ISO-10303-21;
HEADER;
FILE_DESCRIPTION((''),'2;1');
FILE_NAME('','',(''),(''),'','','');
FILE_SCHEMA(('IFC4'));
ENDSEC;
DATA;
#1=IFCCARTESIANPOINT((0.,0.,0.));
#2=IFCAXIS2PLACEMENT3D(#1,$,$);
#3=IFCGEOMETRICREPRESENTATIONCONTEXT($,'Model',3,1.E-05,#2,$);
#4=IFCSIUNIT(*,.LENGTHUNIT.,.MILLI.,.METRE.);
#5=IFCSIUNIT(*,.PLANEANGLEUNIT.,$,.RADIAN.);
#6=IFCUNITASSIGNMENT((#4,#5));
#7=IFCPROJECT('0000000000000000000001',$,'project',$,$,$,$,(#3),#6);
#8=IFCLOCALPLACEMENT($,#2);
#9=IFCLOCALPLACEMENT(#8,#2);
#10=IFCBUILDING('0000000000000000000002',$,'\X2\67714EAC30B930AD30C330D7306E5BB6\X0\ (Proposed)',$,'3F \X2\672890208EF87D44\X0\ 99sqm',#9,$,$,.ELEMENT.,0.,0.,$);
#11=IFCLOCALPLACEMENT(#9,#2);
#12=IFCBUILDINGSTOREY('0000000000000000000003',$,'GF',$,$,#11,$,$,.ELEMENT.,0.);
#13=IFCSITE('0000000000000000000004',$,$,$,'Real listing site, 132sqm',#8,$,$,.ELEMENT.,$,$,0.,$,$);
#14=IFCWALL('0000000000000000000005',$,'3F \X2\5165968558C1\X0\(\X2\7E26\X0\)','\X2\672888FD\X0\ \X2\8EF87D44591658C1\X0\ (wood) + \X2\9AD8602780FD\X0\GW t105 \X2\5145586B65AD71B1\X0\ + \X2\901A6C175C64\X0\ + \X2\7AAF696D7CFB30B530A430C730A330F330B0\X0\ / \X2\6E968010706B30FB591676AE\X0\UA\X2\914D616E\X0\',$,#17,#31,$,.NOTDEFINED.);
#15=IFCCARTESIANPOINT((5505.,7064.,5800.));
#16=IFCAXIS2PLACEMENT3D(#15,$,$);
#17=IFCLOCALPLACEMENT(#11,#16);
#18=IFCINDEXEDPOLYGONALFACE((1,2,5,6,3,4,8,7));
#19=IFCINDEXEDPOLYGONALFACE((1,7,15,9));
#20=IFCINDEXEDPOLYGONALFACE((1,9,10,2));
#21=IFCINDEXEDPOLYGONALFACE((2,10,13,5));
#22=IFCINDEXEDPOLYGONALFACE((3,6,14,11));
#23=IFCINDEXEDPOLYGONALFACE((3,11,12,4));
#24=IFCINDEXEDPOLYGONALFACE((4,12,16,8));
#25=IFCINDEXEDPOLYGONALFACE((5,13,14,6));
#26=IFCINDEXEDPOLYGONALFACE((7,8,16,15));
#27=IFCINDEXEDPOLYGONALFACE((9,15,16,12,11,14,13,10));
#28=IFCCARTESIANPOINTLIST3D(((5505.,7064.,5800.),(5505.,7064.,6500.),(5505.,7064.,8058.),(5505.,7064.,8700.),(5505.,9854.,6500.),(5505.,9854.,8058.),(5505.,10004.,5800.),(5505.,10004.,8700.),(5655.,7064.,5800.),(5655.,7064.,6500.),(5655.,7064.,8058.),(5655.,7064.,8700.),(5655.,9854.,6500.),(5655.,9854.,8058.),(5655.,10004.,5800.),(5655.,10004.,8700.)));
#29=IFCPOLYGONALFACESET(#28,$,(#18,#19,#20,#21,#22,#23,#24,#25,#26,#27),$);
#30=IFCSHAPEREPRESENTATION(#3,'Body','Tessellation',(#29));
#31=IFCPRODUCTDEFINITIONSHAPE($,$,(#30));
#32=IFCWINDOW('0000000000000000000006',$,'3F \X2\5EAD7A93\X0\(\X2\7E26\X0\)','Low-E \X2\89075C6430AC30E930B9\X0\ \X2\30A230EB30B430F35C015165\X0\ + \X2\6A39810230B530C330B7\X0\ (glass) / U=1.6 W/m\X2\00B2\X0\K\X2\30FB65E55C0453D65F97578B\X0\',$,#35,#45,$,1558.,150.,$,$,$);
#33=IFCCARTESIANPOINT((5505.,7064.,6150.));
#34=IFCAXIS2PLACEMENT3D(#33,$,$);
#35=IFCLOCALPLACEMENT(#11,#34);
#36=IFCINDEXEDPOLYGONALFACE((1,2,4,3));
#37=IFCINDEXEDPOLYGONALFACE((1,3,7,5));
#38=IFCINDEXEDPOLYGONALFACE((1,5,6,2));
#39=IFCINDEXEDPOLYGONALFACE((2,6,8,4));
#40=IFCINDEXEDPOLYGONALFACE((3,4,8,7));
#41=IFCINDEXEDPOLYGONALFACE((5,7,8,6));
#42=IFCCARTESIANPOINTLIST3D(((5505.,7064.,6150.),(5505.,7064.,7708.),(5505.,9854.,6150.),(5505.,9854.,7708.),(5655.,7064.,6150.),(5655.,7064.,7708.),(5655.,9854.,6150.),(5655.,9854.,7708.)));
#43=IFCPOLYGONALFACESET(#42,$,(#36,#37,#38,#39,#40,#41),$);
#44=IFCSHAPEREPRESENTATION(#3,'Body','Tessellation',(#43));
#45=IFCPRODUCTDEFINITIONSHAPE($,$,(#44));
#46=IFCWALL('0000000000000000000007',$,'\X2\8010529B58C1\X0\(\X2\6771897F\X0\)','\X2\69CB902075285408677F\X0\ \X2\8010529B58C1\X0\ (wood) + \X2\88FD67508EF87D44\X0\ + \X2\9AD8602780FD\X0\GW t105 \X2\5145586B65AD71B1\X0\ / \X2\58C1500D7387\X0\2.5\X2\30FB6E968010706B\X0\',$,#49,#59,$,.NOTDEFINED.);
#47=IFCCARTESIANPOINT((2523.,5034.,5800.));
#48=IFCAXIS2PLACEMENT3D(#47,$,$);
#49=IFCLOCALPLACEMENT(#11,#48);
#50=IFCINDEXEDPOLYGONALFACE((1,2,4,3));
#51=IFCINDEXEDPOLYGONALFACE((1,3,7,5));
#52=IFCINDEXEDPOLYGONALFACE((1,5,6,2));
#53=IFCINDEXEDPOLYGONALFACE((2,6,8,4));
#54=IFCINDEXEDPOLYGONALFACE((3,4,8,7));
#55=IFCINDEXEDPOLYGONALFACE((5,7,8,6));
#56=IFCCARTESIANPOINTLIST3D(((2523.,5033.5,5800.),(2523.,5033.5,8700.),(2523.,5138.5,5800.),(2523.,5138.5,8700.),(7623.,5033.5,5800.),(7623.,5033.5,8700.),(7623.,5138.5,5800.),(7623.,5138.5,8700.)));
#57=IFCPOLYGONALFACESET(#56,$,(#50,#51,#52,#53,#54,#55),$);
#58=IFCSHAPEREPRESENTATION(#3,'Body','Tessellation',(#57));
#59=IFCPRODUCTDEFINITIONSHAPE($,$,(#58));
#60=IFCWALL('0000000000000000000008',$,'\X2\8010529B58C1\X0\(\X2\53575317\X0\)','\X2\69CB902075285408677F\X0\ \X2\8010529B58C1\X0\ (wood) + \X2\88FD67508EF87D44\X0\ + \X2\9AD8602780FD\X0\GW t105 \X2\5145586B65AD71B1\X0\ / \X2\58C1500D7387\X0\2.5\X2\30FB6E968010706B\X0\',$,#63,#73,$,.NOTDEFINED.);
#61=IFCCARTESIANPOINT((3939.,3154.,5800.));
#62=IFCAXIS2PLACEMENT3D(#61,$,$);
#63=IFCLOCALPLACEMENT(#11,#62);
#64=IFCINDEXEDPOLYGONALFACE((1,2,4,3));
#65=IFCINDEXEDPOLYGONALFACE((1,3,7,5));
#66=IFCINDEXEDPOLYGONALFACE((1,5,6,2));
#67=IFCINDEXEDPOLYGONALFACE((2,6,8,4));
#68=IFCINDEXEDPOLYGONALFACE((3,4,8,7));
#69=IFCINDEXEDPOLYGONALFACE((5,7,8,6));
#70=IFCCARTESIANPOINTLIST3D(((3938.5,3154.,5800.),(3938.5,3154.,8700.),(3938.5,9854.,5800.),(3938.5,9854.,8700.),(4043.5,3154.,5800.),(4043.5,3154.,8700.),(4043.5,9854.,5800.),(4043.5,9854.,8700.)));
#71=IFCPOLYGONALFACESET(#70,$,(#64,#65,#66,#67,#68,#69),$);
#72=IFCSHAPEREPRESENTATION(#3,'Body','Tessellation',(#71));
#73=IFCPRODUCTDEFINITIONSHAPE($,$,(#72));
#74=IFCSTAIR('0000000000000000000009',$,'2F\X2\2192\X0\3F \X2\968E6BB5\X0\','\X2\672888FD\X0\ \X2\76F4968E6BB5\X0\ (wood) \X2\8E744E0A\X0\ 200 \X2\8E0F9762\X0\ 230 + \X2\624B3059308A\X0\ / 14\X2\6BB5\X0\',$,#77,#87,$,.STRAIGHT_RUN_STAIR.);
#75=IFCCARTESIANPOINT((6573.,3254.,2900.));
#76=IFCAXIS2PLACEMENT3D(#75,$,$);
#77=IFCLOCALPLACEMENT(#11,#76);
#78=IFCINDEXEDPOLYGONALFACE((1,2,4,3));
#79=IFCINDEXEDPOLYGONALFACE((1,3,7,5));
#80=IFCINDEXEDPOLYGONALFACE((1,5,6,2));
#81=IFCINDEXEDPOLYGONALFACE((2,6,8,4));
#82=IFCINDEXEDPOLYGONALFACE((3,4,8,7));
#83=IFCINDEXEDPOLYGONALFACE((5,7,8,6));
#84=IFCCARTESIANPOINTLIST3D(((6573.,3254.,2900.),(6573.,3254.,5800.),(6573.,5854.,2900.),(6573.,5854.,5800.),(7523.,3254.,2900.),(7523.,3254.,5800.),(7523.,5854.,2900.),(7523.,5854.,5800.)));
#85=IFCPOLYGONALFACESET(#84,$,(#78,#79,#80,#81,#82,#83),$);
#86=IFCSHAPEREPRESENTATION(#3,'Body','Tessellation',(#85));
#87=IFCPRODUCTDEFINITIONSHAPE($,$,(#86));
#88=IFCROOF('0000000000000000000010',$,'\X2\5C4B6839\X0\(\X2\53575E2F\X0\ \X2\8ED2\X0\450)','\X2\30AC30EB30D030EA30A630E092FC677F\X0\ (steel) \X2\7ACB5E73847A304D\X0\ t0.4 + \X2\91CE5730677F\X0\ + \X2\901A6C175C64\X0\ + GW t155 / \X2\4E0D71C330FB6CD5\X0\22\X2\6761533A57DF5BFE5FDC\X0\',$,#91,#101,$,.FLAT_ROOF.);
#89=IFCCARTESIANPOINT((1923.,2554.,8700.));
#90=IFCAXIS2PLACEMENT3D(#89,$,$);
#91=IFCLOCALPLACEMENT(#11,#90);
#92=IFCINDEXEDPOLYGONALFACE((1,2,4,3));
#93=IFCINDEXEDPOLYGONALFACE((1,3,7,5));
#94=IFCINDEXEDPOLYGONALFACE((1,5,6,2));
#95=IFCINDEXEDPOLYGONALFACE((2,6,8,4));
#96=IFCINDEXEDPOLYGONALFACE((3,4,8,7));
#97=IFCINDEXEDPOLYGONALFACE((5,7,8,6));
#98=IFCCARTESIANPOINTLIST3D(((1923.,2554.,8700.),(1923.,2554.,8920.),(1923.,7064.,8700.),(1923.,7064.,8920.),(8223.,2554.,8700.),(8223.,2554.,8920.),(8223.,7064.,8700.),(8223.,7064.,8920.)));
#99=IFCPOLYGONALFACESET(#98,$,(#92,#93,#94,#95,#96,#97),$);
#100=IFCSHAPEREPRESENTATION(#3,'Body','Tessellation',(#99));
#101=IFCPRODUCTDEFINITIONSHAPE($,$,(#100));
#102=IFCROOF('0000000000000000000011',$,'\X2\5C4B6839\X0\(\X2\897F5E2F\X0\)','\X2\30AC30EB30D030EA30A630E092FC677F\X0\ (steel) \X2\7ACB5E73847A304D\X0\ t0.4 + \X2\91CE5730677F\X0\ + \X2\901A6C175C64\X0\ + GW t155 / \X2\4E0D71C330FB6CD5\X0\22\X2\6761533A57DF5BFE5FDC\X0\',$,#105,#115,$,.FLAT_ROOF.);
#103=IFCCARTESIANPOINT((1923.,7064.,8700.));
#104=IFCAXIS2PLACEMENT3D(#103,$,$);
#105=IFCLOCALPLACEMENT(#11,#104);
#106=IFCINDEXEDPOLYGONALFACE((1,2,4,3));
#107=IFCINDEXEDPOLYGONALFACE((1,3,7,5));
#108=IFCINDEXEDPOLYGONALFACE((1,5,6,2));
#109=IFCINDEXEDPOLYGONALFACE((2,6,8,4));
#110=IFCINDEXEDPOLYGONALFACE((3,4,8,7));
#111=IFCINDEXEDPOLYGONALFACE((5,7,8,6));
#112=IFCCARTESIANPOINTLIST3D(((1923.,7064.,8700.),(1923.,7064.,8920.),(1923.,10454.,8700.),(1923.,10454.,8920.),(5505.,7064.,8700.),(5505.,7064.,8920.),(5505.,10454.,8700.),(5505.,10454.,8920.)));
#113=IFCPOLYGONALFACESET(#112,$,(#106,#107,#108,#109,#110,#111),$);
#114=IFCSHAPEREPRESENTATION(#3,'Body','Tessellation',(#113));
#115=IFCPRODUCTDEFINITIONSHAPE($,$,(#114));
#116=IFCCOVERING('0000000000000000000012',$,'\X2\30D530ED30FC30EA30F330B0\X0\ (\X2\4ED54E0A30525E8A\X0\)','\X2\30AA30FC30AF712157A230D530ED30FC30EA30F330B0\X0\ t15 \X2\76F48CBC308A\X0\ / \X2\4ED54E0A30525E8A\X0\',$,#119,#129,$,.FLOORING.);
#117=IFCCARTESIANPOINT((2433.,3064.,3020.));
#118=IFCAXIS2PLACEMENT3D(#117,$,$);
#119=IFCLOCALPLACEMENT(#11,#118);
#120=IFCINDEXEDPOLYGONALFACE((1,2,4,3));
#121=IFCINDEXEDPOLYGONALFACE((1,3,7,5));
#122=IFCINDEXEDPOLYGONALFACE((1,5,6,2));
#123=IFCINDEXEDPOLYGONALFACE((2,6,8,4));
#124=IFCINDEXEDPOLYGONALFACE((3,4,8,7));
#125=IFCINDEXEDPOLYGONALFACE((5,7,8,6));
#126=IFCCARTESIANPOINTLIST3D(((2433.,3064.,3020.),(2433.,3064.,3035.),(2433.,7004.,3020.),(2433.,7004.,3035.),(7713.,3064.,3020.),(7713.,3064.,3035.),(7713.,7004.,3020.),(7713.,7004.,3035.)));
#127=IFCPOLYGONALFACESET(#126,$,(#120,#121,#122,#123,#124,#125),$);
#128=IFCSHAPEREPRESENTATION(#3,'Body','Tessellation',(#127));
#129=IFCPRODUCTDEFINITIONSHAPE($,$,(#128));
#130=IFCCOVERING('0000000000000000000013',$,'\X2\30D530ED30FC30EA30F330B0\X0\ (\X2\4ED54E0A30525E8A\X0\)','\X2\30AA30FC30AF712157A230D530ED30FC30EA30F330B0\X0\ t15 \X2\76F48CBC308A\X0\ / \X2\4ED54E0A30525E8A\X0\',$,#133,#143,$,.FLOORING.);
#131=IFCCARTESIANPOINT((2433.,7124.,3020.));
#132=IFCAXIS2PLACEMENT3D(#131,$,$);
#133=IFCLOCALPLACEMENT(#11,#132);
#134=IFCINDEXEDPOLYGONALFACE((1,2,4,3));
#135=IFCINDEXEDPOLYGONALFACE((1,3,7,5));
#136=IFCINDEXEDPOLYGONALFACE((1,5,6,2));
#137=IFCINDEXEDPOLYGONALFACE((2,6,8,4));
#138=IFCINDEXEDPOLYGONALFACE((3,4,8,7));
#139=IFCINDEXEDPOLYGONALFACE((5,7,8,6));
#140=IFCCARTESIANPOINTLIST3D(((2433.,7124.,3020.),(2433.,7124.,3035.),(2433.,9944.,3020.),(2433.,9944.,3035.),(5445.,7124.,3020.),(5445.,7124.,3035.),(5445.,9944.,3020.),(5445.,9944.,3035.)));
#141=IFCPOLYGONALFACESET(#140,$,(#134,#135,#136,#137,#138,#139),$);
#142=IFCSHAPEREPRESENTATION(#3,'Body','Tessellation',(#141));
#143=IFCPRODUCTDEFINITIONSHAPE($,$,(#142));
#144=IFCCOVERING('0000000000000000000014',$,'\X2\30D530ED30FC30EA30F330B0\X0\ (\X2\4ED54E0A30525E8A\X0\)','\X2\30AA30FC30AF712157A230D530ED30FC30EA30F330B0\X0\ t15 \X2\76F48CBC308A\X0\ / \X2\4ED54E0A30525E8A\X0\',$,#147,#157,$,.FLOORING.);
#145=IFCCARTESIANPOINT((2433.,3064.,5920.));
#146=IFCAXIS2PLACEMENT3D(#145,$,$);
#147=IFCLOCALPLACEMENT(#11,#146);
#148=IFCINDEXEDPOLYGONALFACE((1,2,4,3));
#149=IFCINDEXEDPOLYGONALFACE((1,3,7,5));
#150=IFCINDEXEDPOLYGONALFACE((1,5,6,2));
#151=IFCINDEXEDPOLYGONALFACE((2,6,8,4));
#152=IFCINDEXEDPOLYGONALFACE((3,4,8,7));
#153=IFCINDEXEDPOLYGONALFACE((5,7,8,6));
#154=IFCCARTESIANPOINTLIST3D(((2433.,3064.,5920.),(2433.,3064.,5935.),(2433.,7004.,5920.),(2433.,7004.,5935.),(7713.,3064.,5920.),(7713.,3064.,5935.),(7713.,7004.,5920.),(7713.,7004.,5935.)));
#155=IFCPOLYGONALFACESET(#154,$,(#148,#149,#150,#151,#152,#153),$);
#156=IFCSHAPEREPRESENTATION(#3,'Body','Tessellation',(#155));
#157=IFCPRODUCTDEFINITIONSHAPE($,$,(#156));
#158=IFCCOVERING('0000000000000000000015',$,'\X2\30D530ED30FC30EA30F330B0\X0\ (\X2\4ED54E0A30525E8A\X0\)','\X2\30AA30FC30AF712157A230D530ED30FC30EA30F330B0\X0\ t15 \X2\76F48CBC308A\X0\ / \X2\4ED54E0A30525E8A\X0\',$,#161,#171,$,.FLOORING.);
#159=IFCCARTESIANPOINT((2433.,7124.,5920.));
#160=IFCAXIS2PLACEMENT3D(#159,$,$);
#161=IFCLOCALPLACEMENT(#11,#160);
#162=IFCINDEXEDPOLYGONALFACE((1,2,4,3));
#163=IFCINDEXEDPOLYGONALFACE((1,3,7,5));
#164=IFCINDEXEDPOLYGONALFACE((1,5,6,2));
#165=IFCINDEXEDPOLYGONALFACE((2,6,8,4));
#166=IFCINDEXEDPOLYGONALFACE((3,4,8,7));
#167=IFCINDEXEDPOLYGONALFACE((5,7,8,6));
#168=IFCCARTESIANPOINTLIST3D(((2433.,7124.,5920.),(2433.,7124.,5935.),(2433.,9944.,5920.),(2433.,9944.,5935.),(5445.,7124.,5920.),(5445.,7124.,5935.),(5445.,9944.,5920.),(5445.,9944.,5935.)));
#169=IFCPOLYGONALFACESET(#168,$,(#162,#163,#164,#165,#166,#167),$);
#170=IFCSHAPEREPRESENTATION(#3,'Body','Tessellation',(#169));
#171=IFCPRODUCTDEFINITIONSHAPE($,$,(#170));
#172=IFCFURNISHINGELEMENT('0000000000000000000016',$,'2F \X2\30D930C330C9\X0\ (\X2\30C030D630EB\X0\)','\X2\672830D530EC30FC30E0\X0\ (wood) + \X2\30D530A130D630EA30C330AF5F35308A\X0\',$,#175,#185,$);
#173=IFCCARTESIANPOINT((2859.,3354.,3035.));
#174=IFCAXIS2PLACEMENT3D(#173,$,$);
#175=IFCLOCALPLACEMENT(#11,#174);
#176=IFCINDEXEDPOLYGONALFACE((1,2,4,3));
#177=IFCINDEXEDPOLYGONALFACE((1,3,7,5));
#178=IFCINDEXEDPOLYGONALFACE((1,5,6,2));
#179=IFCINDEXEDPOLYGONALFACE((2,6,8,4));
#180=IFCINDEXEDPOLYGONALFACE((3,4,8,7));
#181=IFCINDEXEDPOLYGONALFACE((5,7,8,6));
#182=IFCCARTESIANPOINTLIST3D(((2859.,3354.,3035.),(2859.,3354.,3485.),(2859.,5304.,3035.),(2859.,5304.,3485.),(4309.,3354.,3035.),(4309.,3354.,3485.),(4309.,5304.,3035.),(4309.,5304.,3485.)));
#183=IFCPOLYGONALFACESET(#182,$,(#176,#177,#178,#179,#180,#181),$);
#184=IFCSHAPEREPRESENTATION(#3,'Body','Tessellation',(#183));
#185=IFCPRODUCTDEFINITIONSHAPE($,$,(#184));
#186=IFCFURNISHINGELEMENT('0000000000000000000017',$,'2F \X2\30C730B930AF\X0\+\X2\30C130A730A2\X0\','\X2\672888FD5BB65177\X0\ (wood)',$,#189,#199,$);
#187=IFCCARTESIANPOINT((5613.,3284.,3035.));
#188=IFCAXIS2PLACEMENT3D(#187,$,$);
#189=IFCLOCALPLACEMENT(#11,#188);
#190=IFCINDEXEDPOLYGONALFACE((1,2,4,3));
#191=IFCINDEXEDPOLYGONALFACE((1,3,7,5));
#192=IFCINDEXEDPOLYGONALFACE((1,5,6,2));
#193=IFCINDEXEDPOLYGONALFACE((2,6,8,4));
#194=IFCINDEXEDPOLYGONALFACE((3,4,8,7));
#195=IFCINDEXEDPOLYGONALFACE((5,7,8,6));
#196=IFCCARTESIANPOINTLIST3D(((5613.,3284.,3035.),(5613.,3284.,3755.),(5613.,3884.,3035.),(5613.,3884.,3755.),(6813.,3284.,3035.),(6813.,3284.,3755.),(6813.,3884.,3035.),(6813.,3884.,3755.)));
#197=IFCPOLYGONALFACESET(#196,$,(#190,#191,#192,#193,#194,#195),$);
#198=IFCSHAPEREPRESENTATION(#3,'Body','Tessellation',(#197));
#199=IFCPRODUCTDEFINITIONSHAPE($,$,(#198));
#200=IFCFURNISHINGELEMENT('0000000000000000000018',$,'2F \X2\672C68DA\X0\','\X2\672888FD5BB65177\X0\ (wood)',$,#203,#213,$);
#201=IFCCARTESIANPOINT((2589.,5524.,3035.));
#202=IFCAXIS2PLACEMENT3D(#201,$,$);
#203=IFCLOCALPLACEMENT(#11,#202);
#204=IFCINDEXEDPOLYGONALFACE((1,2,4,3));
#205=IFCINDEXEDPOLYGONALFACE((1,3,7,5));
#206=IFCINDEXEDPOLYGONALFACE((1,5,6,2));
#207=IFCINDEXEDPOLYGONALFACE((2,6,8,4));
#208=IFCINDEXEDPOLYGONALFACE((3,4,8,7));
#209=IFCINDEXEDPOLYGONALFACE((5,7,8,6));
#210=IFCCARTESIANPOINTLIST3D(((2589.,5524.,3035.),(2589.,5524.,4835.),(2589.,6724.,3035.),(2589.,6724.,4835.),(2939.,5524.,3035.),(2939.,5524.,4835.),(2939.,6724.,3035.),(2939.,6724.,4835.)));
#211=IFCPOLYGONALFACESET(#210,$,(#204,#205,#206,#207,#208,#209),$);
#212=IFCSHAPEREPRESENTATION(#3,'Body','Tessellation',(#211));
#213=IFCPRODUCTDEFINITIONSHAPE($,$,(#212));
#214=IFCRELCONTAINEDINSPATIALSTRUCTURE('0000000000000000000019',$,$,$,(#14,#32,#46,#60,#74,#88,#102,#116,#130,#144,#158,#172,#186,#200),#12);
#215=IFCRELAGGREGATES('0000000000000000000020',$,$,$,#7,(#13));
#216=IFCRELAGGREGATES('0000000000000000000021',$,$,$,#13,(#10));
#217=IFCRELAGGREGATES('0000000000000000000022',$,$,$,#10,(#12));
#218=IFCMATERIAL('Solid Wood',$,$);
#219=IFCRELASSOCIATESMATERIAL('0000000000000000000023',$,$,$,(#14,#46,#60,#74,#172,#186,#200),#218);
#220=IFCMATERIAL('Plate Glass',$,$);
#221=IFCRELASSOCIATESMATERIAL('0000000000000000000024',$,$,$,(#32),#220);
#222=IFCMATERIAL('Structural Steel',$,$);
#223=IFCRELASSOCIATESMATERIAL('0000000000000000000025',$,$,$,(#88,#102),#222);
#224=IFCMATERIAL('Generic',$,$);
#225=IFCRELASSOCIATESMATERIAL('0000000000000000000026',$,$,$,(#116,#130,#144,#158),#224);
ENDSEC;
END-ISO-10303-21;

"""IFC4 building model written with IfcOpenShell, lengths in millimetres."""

from ifc_helpers import new_model, si_unit, frame, frame_2d, origin, place, context, project, spatial, rectangle, extrude, material, element, fill, save


model = new_model("IFC4")

# Units and contexts
model_context = context("Model", 3, precision=1e-05, world=origin())
ifc_project = project(units=[si_unit("LENGTHUNIT", "METRE", prefix="MILLI"), si_unit("PLANEANGLEUNIT", "RADIAN")], contexts=[model_context])

# Site, building, storey
site_placement = place(None, origin())
site = spatial("IfcSite", under=ifc_project, at=site_placement, ObjectType="Real listing site, 132sqm", CompositionType="ELEMENT", RefElevation=0.0)
building_placement = place(site_placement, origin())
building = spatial("IfcBuilding", under=site, at=building_placement, Name="東京スキップの家 (Proposed)", ObjectType="3F 木造軸組 99sqm", CompositionType="ELEMENT", ElevationOfRefHeight=0.0, ElevationOfTerrain=0.0)
storey_placement = place(building_placement, origin())
storey = spatial("IfcBuildingStorey", under=building, at=storey_placement, Name="GF", CompositionType="ELEMENT", Elevation=0.0)

# Shared definitions
ifc_material_1 = material(Name="Solid Wood")

# Shared definitions
ifc_material_2 = material(Name="Plate Glass")

# Wall, opening, window
wall_1_placement = place(storey_placement, frame((5505.0, 7064.0, 5800.0)))
wall_1 = element("IfcWall", 1, at=wall_1_placement, inside=storey, material=ifc_material_1, Name="3F 入隅壁(縦)", Description="木製 軸組外壁 (wood) + 高性能GW t105 充填断熱 + 通気層 + 窯業系サイディング / 準耐火・外皮UA配慮", PredefinedType="NOTDEFINED", context=model_context, shape_type="SweptSolid", body=[
    extrude(rectangle(XDim=150.0, YDim=2940.0, at=frame_2d((75.0, 1470.0))), frame((5505.0, 7064.0, 5800.0)), (0.0, 0.0, 1.0), 2900.0),
])
opening_1_placement = place(storey_placement, frame((5505.0, 7064.0, 6150.0)))
opening_1 = element("IfcOpeningElement", 2, at=opening_1_placement, cuts=wall_1, PredefinedType="NOTDEFINED", context=model_context, shape_type="SweptSolid", body=[
    extrude(rectangle(XDim=150.0, YDim=2790.0, at=frame_2d((75.0, 1395.0))), frame((5505.0, 7064.0, 6150.0)), (0.0, 0.0, 1.0), 1558.0),
])
window_1_placement = place(storey_placement, frame((5505.0, 7064.0, 6150.0)))
window_1 = element("IfcWindow", 3, at=window_1_placement, inside=storey, material=ifc_material_2, Name="3F 庭窓(縦)", Description="Low-E 複層ガラス アルゴン封入 + 樹脂サッシ (glass) / U=1.6 W/m²K・日射取得型", OverallHeight=1558.0, OverallWidth=150.0, context=model_context, shape_type="SweptSolid", body=[
    extrude(rectangle(XDim=150.0, YDim=2790.0, at=frame_2d((75.0, 1395.0))), frame((5505.0, 7064.0, 6150.0)), (0.0, 0.0, 1.0), 1558.0),
])
fill(opening_1, window_1)

# Walls
wall_2_placement = place(storey_placement, frame((2523.0, 5034.0, 5800.0)))
element("IfcWall", 4, at=wall_2_placement, inside=storey, material=ifc_material_1, Name="耐力壁(東西)", Description="構造用合板 耐力壁 (wood) + 製材軸組 + 高性能GW t105 充填断熱 / 壁倍率2.5・準耐火", PredefinedType="NOTDEFINED", context=model_context, shape_type="SweptSolid", body=[
    extrude(rectangle(XDim=5100.0, YDim=105.0, at=frame_2d((2550.0, 52.0))), frame((2523.0, 5034.0, 5800.0)), (0.0, 0.0, 1.0), 2900.0),
])
wall_3_placement = place(storey_placement, frame((3939.0, 3154.0, 5800.0)))
element("IfcWall", 5, at=wall_3_placement, inside=storey, material=ifc_material_1, Name="耐力壁(南北)", Description="構造用合板 耐力壁 (wood) + 製材軸組 + 高性能GW t105 充填断熱 / 壁倍率2.5・準耐火", PredefinedType="NOTDEFINED", context=model_context, shape_type="SweptSolid", body=[
    extrude(rectangle(XDim=105.0, YDim=6700.0, at=frame_2d((52.0, 3350.0))), frame((3939.0, 3154.0, 5800.0)), (0.0, 0.0, 1.0), 2900.0),
])

# Stair
stair_placement = place(storey_placement, frame((6573.0, 3254.0, 2900.0)))
element("IfcStair", 6, at=stair_placement, inside=storey, material=ifc_material_1, Name="2F→3F 階段", Description="木製 直階段 (wood) 蹴上 200 踏面 230 + 手すり / 14段", PredefinedType="STRAIGHT_RUN_STAIR", context=model_context, shape_type="SweptSolid", body=[
    extrude(rectangle(XDim=950.0, YDim=2600.0, at=frame_2d((475.0, 1300.0))), frame((6573.0, 3254.0, 2900.0)), (0.0, 0.0, 1.0), 2900.0),
])

# Roofs
ifc_material_3 = material(Name="Structural Steel")
roof_1_placement = place(storey_placement, frame((1923.0, 2554.0, 8700.0)))
element("IfcRoof", 7, at=roof_1_placement, inside=storey, material=ifc_material_3, Name="屋根(南帯 軒450)", Description="ガルバリウム鋼板 (steel) 立平葺き t0.4 + 野地板 + 通気層 + GW t155 / 不燃・法22条区域対応", PredefinedType="FLAT_ROOF", context=model_context, shape_type="SweptSolid", body=[
    extrude(rectangle(XDim=6300.0, YDim=4510.0, at=frame_2d((3150.0, 2255.0))), frame((1923.0, 2554.0, 8700.0)), (0.0, 0.0, 1.0), 220.0),
])
roof_2_placement = place(storey_placement, frame((1923.0, 7064.0, 8700.0)))
element("IfcRoof", 8, at=roof_2_placement, inside=storey, material=ifc_material_3, Name="屋根(西帯)", Description="ガルバリウム鋼板 (steel) 立平葺き t0.4 + 野地板 + 通気層 + GW t155 / 不燃・法22条区域対応", PredefinedType="FLAT_ROOF", context=model_context, shape_type="SweptSolid", body=[
    extrude(rectangle(XDim=3582.0, YDim=3390.0, at=frame_2d((1791.0, 1695.0))), frame((1923.0, 7064.0, 8700.0)), (0.0, 0.0, 1.0), 220.0),
])

# Coverings
ifc_material_4 = material(Name="Generic")
covering_1_placement = place(storey_placement, frame((2433.0, 3064.0, 3020.0)))
element("IfcCovering", 9, at=covering_1_placement, inside=storey, material=ifc_material_4, Name="フローリング (仕上げ床)", Description="オーク無垢フローリング t15 直貼り / 仕上げ床", PredefinedType="FLOORING", context=model_context, shape_type="SweptSolid", body=[
    extrude(rectangle(XDim=5280.0, YDim=3940.0, at=frame_2d((2640.0, 1970.0))), frame((2433.0, 3064.0, 3020.0)), (0.0, 0.0, 1.0), 15.0),
])
covering_2_placement = place(storey_placement, frame((2433.0, 7124.0, 3020.0)))
element("IfcCovering", 10, at=covering_2_placement, inside=storey, material=ifc_material_4, Name="フローリング (仕上げ床)", Description="オーク無垢フローリング t15 直貼り / 仕上げ床", PredefinedType="FLOORING", context=model_context, shape_type="SweptSolid", body=[
    extrude(rectangle(XDim=3012.0, YDim=2820.0, at=frame_2d((1506.0, 1410.0))), frame((2433.0, 7124.0, 3020.0)), (0.0, 0.0, 1.0), 15.0),
])
covering_3_placement = place(storey_placement, frame((2433.0, 3064.0, 5920.0)))
element("IfcCovering", 11, at=covering_3_placement, inside=storey, material=ifc_material_4, Name="フローリング (仕上げ床)", Description="オーク無垢フローリング t15 直貼り / 仕上げ床", PredefinedType="FLOORING", context=model_context, shape_type="SweptSolid", body=[
    extrude(rectangle(XDim=5280.0, YDim=3940.0, at=frame_2d((2640.0, 1970.0))), frame((2433.0, 3064.0, 5920.0)), (0.0, 0.0, 1.0), 15.0),
])
covering_4_placement = place(storey_placement, frame((2433.0, 7124.0, 5920.0)))
element("IfcCovering", 12, at=covering_4_placement, inside=storey, material=ifc_material_4, Name="フローリング (仕上げ床)", Description="オーク無垢フローリング t15 直貼り / 仕上げ床", PredefinedType="FLOORING", context=model_context, shape_type="SweptSolid", body=[
    extrude(rectangle(XDim=3012.0, YDim=2820.0, at=frame_2d((1506.0, 1410.0))), frame((2433.0, 7124.0, 5920.0)), (0.0, 0.0, 1.0), 15.0),
])

# Furnishing elements
furnishing_1_placement = place(storey_placement, frame((2859.0, 3354.0, 3035.0)))
element("IfcFurnishingElement", 13, at=furnishing_1_placement, inside=storey, material=ifc_material_1, Name="2F ベッド (ダブル)", Description="木フレーム (wood) + ファブリック張り", context=model_context, shape_type="SweptSolid", body=[
    extrude(rectangle(XDim=1450.0, YDim=1950.0, at=frame_2d((725.0, 975.0))), frame((2859.0, 3354.0, 3035.0)), (0.0, 0.0, 1.0), 450.0),
])
furnishing_2_placement = place(storey_placement, frame((5613.0, 3284.0, 3035.0)))
element("IfcFurnishingElement", 14, at=furnishing_2_placement, inside=storey, material=ifc_material_1, Name="2F デスク+チェア", Description="木製家具 (wood)", context=model_context, shape_type="SweptSolid", body=[
    extrude(rectangle(XDim=1200.0, YDim=600.0, at=frame_2d((600.0, 300.0))), frame((5613.0, 3284.0, 3035.0)), (0.0, 0.0, 1.0), 720.0),
])
furnishing_3_placement = place(storey_placement, frame((2589.0, 5524.0, 3035.0)))
element("IfcFurnishingElement", 15, at=furnishing_3_placement, inside=storey, material=ifc_material_1, Name="2F 本棚", Description="木製家具 (wood)", context=model_context, shape_type="SweptSolid", body=[
    extrude(rectangle(XDim=350.0, YDim=1200.0, at=frame_2d((175.0, 600.0))), frame((2589.0, 5524.0, 3035.0)), (0.0, 0.0, 1.0), 1800.0),
])

save(model, "model.ifc")
